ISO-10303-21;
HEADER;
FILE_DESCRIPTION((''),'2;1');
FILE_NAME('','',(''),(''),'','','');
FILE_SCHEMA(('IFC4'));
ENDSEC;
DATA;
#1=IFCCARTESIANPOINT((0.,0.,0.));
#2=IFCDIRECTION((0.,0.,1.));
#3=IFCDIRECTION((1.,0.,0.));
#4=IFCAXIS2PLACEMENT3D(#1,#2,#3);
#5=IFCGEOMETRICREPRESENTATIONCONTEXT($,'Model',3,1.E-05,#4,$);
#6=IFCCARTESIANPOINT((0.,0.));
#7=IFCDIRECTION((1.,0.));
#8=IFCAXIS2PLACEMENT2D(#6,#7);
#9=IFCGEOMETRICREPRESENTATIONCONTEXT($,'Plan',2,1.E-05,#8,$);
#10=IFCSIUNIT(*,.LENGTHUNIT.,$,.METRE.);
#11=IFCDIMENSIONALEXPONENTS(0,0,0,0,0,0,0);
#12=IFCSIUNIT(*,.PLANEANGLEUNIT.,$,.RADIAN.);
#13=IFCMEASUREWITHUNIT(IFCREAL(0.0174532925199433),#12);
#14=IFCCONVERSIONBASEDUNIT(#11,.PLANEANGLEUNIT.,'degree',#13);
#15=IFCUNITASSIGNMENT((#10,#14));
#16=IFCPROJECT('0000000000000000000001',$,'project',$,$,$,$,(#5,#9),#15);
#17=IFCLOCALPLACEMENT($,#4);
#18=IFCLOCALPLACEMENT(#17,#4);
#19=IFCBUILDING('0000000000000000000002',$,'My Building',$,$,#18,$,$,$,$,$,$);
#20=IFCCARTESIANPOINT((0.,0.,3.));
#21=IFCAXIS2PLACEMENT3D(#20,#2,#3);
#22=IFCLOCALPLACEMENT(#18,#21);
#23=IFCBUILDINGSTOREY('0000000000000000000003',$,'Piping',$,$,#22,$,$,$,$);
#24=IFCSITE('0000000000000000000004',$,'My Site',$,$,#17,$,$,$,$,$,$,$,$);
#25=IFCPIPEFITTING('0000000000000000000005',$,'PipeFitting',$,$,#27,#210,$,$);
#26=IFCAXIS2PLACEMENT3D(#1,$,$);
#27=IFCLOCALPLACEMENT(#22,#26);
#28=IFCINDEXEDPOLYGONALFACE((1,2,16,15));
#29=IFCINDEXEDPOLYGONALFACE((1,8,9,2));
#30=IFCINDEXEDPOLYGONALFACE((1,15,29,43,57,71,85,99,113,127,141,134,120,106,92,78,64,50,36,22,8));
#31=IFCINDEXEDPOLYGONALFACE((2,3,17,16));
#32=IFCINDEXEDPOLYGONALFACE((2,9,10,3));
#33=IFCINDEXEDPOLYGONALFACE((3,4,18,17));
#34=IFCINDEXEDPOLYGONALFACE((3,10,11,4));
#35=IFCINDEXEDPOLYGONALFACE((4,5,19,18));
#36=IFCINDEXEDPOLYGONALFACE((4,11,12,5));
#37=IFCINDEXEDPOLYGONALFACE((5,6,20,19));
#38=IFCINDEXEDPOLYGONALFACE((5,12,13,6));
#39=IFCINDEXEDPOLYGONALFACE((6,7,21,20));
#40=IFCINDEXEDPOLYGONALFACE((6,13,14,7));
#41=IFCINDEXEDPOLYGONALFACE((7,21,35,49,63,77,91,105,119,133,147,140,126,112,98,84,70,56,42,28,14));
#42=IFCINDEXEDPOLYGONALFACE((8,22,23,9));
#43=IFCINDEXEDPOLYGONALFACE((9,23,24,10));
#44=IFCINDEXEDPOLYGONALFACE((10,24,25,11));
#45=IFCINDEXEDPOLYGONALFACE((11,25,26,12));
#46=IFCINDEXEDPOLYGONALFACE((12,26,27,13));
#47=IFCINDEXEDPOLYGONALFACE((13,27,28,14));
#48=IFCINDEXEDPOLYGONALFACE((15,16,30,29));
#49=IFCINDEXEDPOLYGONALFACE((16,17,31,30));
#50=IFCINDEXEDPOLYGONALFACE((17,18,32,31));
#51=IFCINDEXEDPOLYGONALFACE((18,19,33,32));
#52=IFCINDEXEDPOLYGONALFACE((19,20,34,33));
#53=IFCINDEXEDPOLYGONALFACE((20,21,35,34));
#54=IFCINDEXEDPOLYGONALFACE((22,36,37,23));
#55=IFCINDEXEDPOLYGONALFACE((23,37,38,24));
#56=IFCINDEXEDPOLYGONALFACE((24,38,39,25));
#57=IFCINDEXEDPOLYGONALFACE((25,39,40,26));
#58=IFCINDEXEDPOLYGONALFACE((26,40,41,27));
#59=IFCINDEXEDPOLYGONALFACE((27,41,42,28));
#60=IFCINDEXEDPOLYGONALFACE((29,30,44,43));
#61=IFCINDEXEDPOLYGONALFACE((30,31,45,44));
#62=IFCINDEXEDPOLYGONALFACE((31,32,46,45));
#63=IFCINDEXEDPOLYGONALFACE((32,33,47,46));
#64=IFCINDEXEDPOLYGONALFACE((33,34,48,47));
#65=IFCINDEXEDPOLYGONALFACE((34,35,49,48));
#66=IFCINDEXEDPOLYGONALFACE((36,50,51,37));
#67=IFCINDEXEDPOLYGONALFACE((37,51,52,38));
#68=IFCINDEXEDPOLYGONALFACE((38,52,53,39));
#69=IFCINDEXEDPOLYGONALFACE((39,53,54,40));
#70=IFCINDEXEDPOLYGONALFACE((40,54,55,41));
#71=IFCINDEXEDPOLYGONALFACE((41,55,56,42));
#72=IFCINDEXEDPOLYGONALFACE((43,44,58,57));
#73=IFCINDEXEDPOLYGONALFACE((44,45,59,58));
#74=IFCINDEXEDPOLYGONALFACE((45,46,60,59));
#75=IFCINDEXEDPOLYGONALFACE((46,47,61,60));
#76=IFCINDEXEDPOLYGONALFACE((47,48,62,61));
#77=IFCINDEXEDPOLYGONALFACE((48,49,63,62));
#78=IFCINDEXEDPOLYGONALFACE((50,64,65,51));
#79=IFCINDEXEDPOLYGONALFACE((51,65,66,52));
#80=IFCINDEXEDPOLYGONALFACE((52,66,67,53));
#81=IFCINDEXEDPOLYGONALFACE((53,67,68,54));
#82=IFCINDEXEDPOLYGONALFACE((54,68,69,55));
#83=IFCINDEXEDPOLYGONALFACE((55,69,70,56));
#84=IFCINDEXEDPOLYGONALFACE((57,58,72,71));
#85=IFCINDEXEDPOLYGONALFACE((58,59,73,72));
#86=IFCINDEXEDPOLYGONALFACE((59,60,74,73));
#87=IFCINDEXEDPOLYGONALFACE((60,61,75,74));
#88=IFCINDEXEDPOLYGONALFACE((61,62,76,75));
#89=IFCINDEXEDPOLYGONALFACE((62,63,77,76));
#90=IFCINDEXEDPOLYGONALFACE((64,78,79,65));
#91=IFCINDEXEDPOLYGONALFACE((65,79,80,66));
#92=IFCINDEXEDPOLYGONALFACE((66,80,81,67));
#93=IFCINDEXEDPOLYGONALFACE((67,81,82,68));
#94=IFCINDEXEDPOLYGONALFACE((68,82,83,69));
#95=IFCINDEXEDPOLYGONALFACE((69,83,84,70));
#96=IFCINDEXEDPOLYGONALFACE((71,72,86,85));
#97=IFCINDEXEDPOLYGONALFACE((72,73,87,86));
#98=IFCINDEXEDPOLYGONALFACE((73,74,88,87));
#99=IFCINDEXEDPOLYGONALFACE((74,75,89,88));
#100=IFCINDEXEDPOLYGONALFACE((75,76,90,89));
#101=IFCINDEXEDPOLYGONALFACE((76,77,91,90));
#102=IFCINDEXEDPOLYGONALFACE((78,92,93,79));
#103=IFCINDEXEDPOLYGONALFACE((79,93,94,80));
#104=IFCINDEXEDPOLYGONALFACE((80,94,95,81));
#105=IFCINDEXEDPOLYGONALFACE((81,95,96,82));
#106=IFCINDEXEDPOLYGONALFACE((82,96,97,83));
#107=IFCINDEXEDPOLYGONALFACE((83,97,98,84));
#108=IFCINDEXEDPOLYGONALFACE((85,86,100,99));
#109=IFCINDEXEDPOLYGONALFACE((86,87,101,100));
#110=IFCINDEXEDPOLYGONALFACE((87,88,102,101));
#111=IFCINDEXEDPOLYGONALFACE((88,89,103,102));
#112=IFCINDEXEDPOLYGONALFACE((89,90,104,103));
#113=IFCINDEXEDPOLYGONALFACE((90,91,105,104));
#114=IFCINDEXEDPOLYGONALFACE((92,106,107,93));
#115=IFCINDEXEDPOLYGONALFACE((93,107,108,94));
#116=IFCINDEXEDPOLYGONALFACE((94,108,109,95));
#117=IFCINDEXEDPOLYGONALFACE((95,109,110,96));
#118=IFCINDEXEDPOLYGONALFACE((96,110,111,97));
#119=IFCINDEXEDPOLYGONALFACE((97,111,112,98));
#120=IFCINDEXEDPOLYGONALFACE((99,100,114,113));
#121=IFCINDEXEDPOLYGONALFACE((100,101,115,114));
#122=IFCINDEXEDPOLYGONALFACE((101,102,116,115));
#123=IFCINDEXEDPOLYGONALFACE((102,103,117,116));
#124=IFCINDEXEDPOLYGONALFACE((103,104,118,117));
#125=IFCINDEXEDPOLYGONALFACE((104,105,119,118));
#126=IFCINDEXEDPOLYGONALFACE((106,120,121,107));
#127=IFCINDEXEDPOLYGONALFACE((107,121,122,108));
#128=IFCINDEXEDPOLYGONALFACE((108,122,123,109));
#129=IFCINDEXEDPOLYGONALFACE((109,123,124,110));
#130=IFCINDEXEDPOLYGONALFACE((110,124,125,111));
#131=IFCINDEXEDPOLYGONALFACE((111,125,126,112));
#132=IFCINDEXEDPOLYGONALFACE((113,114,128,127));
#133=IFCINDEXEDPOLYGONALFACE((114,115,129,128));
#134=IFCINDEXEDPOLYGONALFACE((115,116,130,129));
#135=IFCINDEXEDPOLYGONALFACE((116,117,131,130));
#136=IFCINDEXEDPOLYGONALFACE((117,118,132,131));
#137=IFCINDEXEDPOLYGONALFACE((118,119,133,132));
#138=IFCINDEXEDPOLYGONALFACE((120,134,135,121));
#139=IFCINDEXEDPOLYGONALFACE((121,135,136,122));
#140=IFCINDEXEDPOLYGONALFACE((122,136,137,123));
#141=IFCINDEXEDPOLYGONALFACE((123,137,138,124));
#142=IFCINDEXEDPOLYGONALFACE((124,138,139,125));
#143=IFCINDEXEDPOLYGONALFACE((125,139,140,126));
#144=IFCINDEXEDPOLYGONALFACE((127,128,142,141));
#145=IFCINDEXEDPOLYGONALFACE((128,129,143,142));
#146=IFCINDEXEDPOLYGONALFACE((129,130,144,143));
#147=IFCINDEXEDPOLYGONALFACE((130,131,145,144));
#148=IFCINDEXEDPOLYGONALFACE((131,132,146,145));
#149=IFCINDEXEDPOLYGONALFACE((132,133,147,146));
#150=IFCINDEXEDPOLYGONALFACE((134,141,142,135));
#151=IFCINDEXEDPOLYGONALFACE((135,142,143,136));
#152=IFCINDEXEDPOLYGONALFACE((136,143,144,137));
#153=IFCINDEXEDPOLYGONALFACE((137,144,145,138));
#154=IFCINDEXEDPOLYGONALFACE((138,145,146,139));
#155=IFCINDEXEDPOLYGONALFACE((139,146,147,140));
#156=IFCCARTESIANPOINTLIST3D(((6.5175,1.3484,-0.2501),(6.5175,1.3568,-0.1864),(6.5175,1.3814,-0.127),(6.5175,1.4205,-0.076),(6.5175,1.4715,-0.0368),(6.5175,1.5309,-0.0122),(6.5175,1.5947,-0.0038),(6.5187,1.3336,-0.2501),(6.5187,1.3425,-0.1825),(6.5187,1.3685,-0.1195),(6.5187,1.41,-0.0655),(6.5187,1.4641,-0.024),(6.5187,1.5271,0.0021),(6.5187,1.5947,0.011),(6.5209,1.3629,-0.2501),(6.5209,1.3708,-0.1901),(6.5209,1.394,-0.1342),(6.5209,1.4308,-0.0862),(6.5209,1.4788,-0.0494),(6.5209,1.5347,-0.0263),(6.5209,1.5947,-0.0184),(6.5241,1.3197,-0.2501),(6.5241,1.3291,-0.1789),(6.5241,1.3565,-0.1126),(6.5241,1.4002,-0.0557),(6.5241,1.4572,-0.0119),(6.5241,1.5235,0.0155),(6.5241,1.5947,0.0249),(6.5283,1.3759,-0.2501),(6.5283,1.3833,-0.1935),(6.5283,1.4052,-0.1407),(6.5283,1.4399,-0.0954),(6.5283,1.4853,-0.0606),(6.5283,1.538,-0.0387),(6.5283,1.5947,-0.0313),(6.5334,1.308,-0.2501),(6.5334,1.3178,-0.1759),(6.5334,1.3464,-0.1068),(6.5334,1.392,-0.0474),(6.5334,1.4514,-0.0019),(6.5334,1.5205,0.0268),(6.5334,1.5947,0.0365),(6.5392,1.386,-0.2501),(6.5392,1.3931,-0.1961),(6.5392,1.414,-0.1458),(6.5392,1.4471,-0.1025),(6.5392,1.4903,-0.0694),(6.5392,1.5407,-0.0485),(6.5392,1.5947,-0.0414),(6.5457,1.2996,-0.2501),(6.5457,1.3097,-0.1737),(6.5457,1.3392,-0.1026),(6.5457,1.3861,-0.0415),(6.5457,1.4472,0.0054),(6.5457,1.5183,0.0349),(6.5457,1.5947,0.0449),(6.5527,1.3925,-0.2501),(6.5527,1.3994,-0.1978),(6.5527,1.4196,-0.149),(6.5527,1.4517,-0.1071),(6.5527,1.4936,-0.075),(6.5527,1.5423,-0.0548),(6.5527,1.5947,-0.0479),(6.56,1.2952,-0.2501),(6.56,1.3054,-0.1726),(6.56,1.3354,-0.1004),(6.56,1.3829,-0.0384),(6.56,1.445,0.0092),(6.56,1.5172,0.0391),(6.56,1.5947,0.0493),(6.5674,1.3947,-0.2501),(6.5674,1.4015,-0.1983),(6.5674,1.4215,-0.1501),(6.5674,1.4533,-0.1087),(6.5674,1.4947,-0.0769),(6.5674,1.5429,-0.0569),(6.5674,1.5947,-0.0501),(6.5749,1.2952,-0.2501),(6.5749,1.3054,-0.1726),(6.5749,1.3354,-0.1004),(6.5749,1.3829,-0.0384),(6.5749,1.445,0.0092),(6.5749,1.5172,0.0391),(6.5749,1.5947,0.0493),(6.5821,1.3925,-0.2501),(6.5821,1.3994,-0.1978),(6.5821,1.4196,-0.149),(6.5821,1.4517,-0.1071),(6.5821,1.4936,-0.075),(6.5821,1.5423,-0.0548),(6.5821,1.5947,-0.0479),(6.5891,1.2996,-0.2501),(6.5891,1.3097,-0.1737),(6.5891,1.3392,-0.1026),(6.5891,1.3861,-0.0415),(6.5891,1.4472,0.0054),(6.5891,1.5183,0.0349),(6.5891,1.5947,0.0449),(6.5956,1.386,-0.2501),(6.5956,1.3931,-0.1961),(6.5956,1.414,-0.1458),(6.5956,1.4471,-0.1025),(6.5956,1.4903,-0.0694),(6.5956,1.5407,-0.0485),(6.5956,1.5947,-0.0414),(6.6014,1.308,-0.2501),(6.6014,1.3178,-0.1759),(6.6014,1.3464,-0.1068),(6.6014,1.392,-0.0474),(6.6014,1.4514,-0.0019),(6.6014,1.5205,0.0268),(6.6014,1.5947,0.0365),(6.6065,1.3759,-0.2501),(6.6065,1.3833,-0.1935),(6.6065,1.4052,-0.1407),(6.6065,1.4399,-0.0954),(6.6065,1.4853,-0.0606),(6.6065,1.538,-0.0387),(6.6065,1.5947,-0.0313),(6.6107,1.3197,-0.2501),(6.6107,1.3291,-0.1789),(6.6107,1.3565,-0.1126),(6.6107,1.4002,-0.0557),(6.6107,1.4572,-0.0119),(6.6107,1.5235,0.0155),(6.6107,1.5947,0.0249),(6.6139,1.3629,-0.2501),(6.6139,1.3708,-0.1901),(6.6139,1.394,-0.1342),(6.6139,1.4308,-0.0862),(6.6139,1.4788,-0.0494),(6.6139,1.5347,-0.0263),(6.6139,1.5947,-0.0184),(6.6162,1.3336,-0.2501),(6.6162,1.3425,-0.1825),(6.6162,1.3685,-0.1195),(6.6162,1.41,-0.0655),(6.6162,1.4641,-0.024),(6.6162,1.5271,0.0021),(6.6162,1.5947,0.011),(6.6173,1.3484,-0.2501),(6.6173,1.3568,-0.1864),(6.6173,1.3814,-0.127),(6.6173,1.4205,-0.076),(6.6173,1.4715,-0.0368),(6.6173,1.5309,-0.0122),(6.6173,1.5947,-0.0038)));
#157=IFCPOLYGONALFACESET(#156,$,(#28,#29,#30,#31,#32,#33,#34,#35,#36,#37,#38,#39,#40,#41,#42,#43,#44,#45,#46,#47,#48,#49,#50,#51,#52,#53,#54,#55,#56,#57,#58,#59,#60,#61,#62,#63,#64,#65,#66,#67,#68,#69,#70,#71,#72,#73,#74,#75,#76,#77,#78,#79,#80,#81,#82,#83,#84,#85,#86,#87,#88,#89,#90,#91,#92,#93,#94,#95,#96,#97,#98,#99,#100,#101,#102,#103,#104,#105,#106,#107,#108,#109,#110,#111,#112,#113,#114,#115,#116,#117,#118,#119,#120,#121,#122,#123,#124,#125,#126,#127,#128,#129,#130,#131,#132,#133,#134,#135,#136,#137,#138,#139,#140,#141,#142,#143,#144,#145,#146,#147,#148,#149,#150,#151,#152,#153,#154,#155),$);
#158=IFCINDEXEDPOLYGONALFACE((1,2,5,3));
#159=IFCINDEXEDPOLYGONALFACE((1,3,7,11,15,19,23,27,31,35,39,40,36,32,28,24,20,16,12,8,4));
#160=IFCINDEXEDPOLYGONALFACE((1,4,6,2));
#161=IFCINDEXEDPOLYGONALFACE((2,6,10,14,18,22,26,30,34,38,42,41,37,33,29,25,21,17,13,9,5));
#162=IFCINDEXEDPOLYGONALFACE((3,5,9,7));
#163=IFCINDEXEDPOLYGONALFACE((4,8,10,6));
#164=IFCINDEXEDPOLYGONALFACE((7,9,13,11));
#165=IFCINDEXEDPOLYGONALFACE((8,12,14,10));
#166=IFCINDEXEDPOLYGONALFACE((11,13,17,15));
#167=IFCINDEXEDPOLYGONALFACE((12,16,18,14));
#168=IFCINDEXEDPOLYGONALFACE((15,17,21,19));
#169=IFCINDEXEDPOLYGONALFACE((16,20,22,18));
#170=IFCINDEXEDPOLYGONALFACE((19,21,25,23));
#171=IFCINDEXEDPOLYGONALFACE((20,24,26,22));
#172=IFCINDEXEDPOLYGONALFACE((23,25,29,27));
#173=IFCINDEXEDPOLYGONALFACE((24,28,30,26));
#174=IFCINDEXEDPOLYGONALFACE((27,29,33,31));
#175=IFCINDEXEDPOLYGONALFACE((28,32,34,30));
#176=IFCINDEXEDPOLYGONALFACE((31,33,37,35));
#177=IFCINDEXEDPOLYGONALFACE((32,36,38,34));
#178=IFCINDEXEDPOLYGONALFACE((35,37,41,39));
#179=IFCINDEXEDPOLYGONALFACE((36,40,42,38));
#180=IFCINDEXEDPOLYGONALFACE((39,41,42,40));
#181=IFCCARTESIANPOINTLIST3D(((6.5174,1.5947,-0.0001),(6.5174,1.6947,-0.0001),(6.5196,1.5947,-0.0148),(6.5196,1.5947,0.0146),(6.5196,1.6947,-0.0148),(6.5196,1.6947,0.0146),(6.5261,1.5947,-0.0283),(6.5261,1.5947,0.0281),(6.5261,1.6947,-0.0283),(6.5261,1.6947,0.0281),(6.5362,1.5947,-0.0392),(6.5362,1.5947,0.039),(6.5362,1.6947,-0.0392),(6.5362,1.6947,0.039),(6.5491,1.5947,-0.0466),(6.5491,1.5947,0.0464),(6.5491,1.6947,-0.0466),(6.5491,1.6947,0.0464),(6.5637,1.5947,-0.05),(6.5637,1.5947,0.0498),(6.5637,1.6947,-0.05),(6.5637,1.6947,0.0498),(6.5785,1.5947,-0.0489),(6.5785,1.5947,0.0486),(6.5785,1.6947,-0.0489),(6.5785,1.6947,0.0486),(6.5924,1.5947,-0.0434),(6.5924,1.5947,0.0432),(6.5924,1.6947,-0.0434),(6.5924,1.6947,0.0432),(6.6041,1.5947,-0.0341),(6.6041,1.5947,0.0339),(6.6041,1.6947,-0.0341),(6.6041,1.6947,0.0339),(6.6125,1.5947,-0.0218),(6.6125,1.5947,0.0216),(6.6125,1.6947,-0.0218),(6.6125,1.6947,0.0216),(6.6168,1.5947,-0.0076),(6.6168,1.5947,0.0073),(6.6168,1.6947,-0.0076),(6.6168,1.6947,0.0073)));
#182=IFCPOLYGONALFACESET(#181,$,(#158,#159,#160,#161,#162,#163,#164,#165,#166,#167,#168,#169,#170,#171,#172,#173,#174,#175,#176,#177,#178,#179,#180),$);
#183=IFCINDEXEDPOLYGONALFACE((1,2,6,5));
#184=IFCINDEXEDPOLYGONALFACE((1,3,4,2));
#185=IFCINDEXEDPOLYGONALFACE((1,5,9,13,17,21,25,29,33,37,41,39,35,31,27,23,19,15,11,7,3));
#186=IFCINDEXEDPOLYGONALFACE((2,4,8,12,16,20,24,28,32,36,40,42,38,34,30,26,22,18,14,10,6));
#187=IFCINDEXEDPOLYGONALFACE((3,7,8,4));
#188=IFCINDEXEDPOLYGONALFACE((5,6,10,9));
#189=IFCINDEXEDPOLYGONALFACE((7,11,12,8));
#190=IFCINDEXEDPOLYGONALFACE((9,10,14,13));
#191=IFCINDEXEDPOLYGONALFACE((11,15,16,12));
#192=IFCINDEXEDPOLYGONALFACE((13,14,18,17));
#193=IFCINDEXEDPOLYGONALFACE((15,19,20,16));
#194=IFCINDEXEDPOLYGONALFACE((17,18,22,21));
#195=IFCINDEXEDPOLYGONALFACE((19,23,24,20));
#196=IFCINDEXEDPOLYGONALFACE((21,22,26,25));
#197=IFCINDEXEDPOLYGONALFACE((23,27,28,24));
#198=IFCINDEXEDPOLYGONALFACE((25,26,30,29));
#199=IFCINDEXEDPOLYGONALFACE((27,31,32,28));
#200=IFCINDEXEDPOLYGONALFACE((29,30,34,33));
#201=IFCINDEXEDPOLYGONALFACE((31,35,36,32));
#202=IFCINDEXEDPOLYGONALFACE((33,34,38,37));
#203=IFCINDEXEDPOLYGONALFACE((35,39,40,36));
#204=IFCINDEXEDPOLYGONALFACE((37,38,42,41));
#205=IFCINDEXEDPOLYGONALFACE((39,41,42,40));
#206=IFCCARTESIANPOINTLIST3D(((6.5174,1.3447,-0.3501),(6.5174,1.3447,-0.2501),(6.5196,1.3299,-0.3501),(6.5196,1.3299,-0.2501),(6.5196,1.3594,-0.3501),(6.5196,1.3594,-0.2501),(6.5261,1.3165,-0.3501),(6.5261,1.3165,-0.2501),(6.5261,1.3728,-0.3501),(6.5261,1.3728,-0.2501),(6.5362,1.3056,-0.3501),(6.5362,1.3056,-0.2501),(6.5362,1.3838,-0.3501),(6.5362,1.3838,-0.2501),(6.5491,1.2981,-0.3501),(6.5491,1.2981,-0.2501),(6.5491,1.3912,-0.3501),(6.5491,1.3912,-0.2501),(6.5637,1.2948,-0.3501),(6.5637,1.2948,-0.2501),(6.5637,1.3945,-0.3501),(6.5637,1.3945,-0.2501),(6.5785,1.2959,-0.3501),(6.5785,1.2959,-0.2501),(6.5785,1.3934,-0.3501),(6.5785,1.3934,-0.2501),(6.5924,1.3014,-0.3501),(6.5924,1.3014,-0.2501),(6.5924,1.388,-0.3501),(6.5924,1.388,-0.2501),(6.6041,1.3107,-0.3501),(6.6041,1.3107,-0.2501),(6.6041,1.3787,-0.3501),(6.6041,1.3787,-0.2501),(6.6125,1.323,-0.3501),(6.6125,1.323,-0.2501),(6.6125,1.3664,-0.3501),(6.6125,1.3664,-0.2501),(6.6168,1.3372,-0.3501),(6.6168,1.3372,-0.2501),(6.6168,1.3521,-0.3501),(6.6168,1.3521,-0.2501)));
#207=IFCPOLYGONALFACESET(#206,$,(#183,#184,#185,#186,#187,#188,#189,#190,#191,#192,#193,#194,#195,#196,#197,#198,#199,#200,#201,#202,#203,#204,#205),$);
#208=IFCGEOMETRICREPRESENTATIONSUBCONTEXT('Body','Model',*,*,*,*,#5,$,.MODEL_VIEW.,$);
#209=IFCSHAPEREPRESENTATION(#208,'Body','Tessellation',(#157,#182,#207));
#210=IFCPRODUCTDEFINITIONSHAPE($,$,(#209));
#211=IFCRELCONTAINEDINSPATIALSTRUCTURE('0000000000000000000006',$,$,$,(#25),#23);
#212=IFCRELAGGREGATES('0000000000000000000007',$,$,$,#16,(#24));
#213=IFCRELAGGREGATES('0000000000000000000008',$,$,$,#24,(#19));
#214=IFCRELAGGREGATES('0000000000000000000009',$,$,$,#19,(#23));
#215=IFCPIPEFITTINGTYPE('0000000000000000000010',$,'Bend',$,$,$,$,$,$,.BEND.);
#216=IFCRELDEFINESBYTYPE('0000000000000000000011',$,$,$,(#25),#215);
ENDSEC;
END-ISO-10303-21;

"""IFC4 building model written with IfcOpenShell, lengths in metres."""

from ifc_helpers import new_model, entity, si_unit, converted_unit, frame, origin_with_axes, origin_2d_with_axis, place, context, subcontext, project, spatial, circle, extrude, source, transform, mapped, type_object, type_shapes, element, save


model = new_model("IFC4")

# Units and contexts
model_context = context("Model", 3, precision=1e-05, world=origin_with_axes())
plan_context = context("Plan", 2, precision=1e-05, world=origin_2d_with_axis())
body_context = subcontext(model_context, "Body", "Model", "MODEL_VIEW")
ifc_project = project(units=[si_unit("LENGTHUNIT", "METRE"), converted_unit("PLANEANGLEUNIT", "degree", entity("IfcReal", 0.0174532925199433), si_unit("PLANEANGLEUNIT", "RADIAN"), dimensions=[0, 0, 0, 0, 0, 0, 0])], contexts=[model_context, plan_context])

# Site, building, storey
site_placement = place(None, origin_with_axes())
site = spatial("IfcSite", under=ifc_project, at=site_placement, Name="My Site")
building_placement = place(site_placement, origin_with_axes())
building = spatial("IfcBuilding", under=site, at=building_placement, Name="My Building")
storey_placement = place(building_placement, frame((0.0, 0.0, 3.0), z_axis=(0.0, 0.0, 1.0), x_axis=(1.0, 0.0, 0.0)))
storey = spatial("IfcBuildingStorey", under=building, at=storey_placement, Name="Piping")

# Pipe fitting
pipe_fitting_type = type_object("IfcPipeFittingType", Name="Bend", PredefinedType="BEND")
shared_shape = source(origin_with_axes(), body_context, "Body", "SolidModel", [
    entity("IfcSweptDiskSolid", entity("IfcIndexedPolyCurve", entity("IfcCartesianPointList3D", [[0.0, 0.0, -0.1], [0.0, -0.0732, -0.2768], [0.0, -0.25, -0.35]]), [entity("IfcArcIndex", [1, 2, 3])]), 0.05),
    extrude(circle(Radius=0.05), origin_with_axes(), (0.0, 0.0, -1.0), 0.1),
    extrude(circle(Radius=0.05), frame((0.0, -0.25, -0.35), z_axis=(0.0, -1.0, 0.0), x_axis=(1.0, 0.0, 0.0)), (0.0, 0.0, 1.0), 0.1),
])
type_shapes(pipe_fitting_type, [shared_shape])
for number, where, z_axis, x_axis, name in (
    (1, (6.5674, 1.6947, -0.0001), (0.0, 1.0, 0.0), (-1.0, 0.0, 0.0), "PipeFitting"),
):
    element("IfcPipeFitting", number, at=place(storey_placement, frame(where, z_axis=z_axis, x_axis=x_axis)), inside=storey, type_object=pipe_fitting_type, Name=name, context=body_context, shape_type="MappedRepresentation", body=[
        mapped(shared_shape, transform((0.0, 0.0, 0.0), x_axis=(1.0, 0.0, 0.0), y_axis=(0.0, 1.0, 0.0), z_axis=(0.0, 0.0, 1.0), scale=1.0)),
    ])

save(model, "model.ifc")
